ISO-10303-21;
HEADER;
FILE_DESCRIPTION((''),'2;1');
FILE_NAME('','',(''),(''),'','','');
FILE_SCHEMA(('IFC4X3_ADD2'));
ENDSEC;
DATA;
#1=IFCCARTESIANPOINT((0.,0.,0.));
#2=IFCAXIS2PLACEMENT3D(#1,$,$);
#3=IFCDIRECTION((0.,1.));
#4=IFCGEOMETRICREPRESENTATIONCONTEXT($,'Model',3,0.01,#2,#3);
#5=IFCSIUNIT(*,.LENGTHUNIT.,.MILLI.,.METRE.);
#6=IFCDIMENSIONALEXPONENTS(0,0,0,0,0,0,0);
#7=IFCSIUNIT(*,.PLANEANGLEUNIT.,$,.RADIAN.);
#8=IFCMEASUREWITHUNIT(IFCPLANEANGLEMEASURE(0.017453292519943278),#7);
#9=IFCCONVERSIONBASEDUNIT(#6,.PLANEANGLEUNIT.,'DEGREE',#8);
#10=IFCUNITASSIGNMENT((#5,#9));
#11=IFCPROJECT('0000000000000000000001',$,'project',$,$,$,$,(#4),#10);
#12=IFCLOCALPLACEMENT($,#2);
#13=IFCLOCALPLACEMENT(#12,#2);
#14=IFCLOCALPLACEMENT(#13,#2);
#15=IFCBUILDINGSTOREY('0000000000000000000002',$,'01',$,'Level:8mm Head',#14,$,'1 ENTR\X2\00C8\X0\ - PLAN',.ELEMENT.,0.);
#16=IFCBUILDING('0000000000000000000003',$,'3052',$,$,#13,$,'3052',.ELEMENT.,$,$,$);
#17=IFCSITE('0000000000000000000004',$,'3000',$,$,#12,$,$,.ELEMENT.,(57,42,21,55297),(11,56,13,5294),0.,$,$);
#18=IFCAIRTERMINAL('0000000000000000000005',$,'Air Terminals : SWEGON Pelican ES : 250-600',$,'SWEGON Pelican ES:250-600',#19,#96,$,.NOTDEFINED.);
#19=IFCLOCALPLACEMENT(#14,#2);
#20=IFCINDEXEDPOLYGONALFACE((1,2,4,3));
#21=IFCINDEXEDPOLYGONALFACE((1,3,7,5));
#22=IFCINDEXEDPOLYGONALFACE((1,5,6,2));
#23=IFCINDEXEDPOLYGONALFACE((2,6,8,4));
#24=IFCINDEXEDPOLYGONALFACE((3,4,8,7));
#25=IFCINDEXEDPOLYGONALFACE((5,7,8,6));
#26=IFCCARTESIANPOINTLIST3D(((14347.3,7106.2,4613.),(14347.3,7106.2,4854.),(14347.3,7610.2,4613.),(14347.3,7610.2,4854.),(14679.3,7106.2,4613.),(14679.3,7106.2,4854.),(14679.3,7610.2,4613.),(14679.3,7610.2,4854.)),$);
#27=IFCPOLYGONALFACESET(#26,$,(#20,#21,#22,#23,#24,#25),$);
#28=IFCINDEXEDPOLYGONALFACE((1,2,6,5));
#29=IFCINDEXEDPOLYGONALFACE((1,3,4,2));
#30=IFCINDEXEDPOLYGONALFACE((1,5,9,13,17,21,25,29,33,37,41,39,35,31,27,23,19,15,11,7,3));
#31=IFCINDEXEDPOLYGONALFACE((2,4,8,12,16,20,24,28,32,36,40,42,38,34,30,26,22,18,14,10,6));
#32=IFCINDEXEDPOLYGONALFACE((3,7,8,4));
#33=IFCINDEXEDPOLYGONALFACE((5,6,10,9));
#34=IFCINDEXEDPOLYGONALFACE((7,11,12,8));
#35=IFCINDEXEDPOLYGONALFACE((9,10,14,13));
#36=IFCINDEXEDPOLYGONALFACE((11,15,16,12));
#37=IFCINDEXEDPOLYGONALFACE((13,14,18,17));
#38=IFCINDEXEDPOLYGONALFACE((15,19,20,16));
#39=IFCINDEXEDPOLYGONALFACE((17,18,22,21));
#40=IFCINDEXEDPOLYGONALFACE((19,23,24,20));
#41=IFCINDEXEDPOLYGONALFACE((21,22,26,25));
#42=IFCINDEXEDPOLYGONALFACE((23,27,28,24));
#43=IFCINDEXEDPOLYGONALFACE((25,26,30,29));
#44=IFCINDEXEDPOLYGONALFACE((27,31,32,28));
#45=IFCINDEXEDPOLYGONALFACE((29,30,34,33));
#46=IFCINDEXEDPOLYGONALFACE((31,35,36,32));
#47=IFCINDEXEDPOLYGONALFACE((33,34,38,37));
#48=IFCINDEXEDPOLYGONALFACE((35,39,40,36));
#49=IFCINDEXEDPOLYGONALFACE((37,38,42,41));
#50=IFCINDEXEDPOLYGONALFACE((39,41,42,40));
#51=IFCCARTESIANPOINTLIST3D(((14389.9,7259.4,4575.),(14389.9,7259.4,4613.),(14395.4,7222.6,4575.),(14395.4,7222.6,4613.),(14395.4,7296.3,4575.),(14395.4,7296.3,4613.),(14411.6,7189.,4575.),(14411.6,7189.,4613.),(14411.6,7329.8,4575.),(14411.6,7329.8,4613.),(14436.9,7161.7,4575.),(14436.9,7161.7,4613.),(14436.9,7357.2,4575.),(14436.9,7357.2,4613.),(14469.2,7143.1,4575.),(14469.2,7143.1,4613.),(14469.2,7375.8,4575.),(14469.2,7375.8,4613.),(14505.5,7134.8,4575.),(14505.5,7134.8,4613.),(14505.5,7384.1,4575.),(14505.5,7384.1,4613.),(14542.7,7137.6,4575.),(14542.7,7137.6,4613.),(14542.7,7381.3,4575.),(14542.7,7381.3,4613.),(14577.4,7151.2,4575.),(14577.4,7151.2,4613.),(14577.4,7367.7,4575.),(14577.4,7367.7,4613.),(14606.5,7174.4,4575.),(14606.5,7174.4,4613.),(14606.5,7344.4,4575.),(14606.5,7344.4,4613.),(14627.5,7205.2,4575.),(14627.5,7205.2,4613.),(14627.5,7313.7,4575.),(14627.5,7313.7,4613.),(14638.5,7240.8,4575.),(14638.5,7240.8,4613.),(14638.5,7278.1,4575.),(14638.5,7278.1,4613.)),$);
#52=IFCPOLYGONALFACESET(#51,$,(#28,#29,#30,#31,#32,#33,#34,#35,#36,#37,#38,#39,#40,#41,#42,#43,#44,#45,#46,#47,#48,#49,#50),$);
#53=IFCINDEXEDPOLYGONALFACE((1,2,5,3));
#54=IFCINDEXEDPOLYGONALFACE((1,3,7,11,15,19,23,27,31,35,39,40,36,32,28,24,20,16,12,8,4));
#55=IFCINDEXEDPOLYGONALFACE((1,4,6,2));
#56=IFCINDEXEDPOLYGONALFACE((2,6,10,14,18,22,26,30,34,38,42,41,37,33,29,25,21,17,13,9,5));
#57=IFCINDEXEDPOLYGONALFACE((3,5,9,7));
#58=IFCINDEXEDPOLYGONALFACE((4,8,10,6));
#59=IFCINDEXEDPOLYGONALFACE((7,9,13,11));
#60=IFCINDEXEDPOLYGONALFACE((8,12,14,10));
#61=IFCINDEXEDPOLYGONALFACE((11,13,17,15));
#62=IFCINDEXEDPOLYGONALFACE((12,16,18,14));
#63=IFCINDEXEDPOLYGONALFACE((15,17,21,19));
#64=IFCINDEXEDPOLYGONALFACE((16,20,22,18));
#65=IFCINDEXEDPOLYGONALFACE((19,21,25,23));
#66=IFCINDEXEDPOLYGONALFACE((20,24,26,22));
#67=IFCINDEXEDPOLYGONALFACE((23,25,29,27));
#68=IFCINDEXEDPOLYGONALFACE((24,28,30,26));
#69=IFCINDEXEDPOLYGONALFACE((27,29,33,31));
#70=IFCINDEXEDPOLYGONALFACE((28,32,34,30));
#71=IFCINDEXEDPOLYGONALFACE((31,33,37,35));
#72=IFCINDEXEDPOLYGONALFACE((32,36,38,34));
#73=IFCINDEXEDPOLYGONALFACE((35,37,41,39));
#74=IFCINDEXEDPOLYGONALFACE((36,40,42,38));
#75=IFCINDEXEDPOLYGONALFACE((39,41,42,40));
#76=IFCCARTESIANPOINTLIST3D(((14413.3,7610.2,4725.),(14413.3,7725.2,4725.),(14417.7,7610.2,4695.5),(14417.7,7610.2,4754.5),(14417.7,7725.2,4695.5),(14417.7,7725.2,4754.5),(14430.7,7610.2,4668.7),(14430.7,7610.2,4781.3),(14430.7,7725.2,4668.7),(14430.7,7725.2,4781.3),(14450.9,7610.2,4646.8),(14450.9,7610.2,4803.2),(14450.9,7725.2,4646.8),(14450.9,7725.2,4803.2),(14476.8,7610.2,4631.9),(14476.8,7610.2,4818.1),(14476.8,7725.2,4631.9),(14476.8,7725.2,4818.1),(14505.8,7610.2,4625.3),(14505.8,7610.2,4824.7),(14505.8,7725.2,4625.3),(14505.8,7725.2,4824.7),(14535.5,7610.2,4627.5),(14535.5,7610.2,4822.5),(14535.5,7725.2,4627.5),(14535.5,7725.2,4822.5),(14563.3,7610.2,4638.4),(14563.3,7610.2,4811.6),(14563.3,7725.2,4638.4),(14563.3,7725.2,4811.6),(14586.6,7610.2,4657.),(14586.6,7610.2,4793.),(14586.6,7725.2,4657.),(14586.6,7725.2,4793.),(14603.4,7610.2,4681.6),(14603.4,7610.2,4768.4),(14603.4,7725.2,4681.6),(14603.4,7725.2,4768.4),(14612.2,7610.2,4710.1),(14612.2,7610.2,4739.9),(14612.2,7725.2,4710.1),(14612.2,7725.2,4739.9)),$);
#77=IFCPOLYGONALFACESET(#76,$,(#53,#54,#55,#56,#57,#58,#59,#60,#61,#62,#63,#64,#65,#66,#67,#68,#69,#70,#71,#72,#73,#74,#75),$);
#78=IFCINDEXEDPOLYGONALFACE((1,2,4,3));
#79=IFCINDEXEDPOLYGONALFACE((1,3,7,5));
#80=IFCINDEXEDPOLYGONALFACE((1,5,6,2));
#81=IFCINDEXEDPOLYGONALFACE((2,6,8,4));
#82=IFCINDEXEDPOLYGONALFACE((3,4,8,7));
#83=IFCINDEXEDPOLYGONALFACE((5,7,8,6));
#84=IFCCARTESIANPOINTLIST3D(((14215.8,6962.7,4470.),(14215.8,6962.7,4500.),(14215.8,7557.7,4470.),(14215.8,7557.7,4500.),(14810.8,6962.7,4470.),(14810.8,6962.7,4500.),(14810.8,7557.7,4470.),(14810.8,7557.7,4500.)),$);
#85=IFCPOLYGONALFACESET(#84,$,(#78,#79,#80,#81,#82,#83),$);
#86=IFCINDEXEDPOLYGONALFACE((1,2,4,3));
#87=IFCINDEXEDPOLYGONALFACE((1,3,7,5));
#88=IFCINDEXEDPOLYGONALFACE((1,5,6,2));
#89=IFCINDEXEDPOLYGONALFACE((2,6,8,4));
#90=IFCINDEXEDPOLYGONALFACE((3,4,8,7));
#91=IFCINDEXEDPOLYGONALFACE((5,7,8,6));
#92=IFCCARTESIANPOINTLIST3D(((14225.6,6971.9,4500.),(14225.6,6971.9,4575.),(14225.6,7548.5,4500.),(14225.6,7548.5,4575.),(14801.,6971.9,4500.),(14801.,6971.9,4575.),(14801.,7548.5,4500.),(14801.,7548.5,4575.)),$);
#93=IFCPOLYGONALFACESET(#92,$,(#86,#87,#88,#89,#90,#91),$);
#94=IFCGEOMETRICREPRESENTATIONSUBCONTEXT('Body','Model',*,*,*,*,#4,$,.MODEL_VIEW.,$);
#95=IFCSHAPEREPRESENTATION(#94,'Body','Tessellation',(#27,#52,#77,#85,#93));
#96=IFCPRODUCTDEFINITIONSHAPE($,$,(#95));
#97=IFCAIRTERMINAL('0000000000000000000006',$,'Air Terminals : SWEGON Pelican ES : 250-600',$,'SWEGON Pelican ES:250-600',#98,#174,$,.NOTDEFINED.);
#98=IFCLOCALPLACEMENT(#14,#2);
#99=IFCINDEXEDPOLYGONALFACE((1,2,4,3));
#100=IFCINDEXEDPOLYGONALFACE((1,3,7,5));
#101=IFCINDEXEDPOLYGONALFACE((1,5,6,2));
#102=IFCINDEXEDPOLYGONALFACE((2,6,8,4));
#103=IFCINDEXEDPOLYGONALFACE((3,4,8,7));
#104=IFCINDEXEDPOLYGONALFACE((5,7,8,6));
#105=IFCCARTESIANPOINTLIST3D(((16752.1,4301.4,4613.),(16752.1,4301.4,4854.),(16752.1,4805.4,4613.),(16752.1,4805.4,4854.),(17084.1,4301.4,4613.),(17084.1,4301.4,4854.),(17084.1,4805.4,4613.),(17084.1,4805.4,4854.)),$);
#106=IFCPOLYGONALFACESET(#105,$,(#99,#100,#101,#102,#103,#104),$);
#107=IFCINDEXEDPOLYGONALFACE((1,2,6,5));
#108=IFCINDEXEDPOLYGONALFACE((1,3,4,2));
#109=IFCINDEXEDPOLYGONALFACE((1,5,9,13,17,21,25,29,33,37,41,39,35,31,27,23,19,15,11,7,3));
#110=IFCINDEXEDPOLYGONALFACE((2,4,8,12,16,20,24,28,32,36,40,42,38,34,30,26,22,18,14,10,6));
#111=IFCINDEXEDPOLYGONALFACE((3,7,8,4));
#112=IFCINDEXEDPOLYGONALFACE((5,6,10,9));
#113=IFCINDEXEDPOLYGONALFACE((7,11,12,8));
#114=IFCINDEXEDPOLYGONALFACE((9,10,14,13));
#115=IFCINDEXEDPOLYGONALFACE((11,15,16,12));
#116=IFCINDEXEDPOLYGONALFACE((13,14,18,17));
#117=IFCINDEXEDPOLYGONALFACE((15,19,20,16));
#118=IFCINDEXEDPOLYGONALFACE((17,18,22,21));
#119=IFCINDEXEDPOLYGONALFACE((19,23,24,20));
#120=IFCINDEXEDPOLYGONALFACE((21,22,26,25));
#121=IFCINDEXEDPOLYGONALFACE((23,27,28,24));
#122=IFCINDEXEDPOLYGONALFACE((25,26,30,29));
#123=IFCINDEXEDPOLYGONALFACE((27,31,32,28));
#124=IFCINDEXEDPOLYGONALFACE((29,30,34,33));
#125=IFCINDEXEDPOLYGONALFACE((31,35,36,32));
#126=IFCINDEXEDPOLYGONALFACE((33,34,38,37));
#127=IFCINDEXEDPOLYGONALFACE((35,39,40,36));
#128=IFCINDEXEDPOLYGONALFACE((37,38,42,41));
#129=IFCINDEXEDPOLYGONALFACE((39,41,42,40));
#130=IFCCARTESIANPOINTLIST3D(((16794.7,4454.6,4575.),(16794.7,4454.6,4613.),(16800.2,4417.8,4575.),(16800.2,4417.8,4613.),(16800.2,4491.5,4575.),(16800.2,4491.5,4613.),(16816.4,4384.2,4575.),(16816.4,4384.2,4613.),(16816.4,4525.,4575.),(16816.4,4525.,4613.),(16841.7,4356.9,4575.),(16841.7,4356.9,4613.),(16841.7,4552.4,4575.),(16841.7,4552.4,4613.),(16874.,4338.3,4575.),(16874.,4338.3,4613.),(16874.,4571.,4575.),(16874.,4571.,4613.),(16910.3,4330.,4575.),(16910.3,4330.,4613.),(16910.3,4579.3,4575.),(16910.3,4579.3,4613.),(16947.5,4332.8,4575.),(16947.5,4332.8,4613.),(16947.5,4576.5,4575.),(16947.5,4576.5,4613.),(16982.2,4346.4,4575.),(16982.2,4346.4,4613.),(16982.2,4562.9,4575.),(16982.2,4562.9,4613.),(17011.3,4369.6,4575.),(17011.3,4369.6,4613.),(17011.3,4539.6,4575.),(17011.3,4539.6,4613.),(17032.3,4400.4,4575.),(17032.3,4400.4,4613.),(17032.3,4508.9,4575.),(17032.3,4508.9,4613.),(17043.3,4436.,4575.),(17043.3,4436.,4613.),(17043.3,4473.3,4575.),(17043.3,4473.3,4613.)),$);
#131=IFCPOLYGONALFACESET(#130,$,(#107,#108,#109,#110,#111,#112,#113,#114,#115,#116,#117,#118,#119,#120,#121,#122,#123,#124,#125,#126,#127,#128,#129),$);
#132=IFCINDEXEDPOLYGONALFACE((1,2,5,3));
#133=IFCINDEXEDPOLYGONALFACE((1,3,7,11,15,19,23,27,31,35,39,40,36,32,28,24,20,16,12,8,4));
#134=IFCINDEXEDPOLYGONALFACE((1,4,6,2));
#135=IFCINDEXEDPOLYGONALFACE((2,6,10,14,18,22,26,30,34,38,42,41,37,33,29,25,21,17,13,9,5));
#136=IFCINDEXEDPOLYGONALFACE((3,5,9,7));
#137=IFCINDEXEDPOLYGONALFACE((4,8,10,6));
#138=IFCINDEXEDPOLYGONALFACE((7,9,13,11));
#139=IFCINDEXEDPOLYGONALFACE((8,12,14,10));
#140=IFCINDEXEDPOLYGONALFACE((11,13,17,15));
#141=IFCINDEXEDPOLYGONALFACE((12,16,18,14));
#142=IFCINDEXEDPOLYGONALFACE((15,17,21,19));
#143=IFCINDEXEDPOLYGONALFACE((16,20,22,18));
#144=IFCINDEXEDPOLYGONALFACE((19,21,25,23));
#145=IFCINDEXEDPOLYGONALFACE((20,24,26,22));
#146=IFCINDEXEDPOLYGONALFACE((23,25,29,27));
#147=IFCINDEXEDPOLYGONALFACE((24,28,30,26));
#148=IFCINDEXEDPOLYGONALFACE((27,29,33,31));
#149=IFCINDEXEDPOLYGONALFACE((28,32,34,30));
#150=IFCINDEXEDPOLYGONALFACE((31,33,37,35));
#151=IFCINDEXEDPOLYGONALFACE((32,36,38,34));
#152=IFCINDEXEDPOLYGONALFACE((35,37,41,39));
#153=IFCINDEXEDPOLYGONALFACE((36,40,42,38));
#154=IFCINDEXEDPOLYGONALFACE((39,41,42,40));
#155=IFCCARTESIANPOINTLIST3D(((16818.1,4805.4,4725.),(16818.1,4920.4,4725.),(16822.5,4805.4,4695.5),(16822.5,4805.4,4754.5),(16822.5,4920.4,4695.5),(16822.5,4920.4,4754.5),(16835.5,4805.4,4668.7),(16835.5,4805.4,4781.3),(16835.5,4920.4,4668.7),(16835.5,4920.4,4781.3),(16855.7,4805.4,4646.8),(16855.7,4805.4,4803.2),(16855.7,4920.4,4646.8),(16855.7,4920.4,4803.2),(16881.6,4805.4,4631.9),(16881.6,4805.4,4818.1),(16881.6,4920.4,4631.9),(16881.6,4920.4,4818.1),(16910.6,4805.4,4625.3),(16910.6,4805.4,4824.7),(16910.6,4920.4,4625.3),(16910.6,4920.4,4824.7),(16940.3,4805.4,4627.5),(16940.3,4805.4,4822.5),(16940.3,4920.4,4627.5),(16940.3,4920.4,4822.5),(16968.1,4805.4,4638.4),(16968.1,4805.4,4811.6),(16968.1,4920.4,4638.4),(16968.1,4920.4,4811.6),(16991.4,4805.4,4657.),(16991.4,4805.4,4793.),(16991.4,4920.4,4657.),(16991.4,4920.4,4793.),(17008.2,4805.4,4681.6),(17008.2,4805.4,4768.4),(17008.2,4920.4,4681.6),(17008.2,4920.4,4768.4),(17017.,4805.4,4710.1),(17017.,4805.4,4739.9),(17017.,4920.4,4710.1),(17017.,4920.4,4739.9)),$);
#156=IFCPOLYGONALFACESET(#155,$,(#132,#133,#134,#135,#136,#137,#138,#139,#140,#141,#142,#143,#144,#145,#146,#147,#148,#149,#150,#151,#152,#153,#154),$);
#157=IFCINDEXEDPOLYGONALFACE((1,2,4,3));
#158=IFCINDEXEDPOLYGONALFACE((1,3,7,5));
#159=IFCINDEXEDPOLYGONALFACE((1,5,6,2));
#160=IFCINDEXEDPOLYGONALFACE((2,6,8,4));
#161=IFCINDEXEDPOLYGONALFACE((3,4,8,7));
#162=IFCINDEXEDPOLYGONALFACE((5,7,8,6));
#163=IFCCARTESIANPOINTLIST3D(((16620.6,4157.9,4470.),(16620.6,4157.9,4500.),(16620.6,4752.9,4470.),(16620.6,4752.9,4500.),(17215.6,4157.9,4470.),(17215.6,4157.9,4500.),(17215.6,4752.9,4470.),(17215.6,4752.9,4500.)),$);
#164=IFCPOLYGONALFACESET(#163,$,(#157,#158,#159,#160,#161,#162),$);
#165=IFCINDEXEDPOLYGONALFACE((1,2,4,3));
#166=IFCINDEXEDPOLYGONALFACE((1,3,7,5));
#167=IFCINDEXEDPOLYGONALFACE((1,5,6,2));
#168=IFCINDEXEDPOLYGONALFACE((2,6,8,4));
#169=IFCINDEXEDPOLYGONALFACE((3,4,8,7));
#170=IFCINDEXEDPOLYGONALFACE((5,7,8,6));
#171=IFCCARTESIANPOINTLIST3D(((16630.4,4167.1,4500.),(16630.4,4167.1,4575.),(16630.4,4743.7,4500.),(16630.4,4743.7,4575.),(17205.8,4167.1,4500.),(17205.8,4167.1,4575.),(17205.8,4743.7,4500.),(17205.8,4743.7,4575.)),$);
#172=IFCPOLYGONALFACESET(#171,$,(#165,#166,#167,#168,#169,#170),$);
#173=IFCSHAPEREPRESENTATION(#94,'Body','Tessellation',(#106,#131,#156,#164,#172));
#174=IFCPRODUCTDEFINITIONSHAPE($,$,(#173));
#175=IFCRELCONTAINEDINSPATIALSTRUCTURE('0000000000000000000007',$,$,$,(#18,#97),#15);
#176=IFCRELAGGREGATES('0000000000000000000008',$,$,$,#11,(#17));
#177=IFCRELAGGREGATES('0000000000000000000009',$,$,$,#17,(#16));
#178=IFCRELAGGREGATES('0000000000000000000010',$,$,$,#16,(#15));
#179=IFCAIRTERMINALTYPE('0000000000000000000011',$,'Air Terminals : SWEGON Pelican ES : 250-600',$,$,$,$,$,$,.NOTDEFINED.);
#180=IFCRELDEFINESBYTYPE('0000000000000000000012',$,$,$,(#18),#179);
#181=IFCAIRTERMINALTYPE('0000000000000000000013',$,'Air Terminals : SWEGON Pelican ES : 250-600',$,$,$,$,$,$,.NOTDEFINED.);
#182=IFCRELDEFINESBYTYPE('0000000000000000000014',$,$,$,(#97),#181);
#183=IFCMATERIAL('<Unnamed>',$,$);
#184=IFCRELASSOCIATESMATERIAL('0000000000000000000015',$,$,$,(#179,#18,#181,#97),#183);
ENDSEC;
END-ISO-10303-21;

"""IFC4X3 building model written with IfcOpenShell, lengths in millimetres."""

from ifc_helpers import new_model, entity, si_unit, converted_unit, direction, frame, frame_2d, origin, origin_2d_with_axis, place, context, subcontext, project, spatial, rectangle, circle, extrude, source, transform, mapped, material, type_object, type_shapes, element, save


model = new_model("IFC4X3")

# Units and contexts
model_context = context("Model", 3, precision=0.01, world=origin(), true_north=direction((0.0, 1.0)))
body_context = subcontext(model_context, "Body", "Model", "MODEL_VIEW")
ifc_project = project(units=[si_unit("LENGTHUNIT", "METRE", prefix="MILLI"), converted_unit("PLANEANGLEUNIT", "DEGREE", entity("IfcPlaneAngleMeasure", 0.017453292519943278), si_unit("PLANEANGLEUNIT", "RADIAN"), dimensions=[0, 0, 0, 0, 0, 0, 0])], contexts=[model_context])

# Site, building, storey
site_placement = place(None, origin())
site = spatial("IfcSite", under=ifc_project, at=site_placement, Name="3000", CompositionType="ELEMENT", RefLatitude=(57, 42, 21, 55297), RefLongitude=(11, 56, 13, 5294), RefElevation=0.0)
building_placement = place(site_placement, origin())
building = spatial("IfcBuilding", under=site, at=building_placement, Name="3052", LongName="3052", CompositionType="ELEMENT")
storey_placement = place(building_placement, origin())
storey = spatial("IfcBuildingStorey", under=building, at=storey_placement, Name="01", ObjectType="Level:8mm Head", LongName="1 ENTRÈ - PLAN", CompositionType="ELEMENT", Elevation=0.0)

# Shared definitions
ifc_material_1 = material(Name="<Unnamed>")

# Air terminals
air_terminal_type_1 = type_object("IfcAirTerminalType", Name="Air Terminals : SWEGON Pelican ES : 250-600", PredefinedType="NOTDEFINED", material=ifc_material_1)
shared_shape_1 = source(origin(), body_context, "Body", "SweptSolid", [
    extrude(rectangle(XDim=332.0, YDim=504.0, at=origin_2d_with_axis()), frame((0.0, 98.0, -354.0), z_axis=(0.0, 0.0, 1.0), x_axis=(-1.0, 0.0, 0.0)), (0.0, 0.0, 1.0), 241.0),
    extrude(circle(Radius=125.0, at=frame_2d((0.0, 0.0), x_axis=(1.0, 0.0))), frame((-1.6, -0.8, -113.0)), (0.0, 0.0, 1.0), 38.0),
    extrude(circle(Radius=100.0, at=frame_2d((0.0, 0.0), x_axis=(1.0, 0.0))), frame((0.0, 350.0, -225.0), z_axis=(0.0, 1.0, 0.0), x_axis=(1.0, 0.0, 0.0)), (0.0, 0.0, 1.0), 115.0),
    extrude(rectangle(XDim=595.0, YDim=595.0, at=frame_2d((0.0, 0.0), x_axis=(1.0, 0.0))), frame((0.0, 0.0, 0.0), z_axis=(0.0, 0.0, 1.0), x_axis=(-1.0, 0.0, 0.0)), (0.0, 0.0, 1.0), 30.0),
    extrude(rectangle(XDim=575.5, YDim=576.5, at=origin_2d_with_axis()), frame((0.0, 0.0, -75.0), z_axis=(0.0, 0.0, 1.0), x_axis=(-1.0, 0.0, 0.0)), (0.0, 0.0, 1.0), 75.0),
])
type_shapes(air_terminal_type_1, [shared_shape_1])
air_terminal_1_placement = place(storey_placement, frame((14513.3, 7260.2, 4500.0), z_axis=(0.0, 0.0, -1.0), x_axis=(-1.0, 0.0, 0.0)))
element("IfcAirTerminal", 1, at=air_terminal_1_placement, inside=storey, type_object=air_terminal_type_1, material=ifc_material_1, Name="Air Terminals : SWEGON Pelican ES : 250-600", ObjectType="SWEGON Pelican ES:250-600", PredefinedType="NOTDEFINED", context=body_context, shape_type="MappedRepresentation", body=[
    mapped(shared_shape_1, transform((0.0, 0.0, 0.0), scale=1.0)),
])
air_terminal_type_2 = type_object("IfcAirTerminalType", Name="Air Terminals : SWEGON Pelican ES : 250-600", PredefinedType="NOTDEFINED", material=ifc_material_1)
shared_shape_2 = source(origin(), body_context, "Body", "SweptSolid", [
    extrude(rectangle(XDim=332.0, YDim=504.0, at=origin_2d_with_axis()), frame((0.0, 98.0, -354.0), z_axis=(0.0, 0.0, 1.0), x_axis=(-1.0, 0.0, 0.0)), (0.0, 0.0, 1.0), 241.0),
    extrude(circle(Radius=125.0, at=frame_2d((0.0, 0.0), x_axis=(1.0, 0.0))), frame((-1.6, -0.8, -113.0)), (0.0, 0.0, 1.0), 38.0),
    extrude(circle(Radius=100.0, at=frame_2d((0.0, 0.0), x_axis=(1.0, 0.0))), frame((0.0, 350.0, -225.0), z_axis=(0.0, 1.0, 0.0), x_axis=(1.0, 0.0, 0.0)), (0.0, 0.0, 1.0), 115.0),
    extrude(rectangle(XDim=595.0, YDim=595.0, at=frame_2d((0.0, 0.0), x_axis=(1.0, 0.0))), frame((0.0, 0.0, 0.0), z_axis=(0.0, 0.0, 1.0), x_axis=(-1.0, 0.0, 0.0)), (0.0, 0.0, 1.0), 30.0),
    extrude(rectangle(XDim=575.5, YDim=576.5, at=origin_2d_with_axis()), frame((0.0, 0.0, -75.0), z_axis=(0.0, 0.0, 1.0), x_axis=(-1.0, 0.0, 0.0)), (0.0, 0.0, 1.0), 75.0),
])
type_shapes(air_terminal_type_2, [shared_shape_2])
air_terminal_2_placement = place(storey_placement, frame((16918.1, 4455.4, 4500.0), z_axis=(0.0, 0.0, -1.0), x_axis=(-1.0, 0.0, 0.0)))
element("IfcAirTerminal", 2, at=air_terminal_2_placement, inside=storey, type_object=air_terminal_type_2, material=ifc_material_1, Name="Air Terminals : SWEGON Pelican ES : 250-600", ObjectType="SWEGON Pelican ES:250-600", PredefinedType="NOTDEFINED", context=body_context, shape_type="MappedRepresentation", body=[
    mapped(shared_shape_2, transform((0.0, 0.0, 0.0), scale=1.0)),
])

save(model, "model.ifc")
